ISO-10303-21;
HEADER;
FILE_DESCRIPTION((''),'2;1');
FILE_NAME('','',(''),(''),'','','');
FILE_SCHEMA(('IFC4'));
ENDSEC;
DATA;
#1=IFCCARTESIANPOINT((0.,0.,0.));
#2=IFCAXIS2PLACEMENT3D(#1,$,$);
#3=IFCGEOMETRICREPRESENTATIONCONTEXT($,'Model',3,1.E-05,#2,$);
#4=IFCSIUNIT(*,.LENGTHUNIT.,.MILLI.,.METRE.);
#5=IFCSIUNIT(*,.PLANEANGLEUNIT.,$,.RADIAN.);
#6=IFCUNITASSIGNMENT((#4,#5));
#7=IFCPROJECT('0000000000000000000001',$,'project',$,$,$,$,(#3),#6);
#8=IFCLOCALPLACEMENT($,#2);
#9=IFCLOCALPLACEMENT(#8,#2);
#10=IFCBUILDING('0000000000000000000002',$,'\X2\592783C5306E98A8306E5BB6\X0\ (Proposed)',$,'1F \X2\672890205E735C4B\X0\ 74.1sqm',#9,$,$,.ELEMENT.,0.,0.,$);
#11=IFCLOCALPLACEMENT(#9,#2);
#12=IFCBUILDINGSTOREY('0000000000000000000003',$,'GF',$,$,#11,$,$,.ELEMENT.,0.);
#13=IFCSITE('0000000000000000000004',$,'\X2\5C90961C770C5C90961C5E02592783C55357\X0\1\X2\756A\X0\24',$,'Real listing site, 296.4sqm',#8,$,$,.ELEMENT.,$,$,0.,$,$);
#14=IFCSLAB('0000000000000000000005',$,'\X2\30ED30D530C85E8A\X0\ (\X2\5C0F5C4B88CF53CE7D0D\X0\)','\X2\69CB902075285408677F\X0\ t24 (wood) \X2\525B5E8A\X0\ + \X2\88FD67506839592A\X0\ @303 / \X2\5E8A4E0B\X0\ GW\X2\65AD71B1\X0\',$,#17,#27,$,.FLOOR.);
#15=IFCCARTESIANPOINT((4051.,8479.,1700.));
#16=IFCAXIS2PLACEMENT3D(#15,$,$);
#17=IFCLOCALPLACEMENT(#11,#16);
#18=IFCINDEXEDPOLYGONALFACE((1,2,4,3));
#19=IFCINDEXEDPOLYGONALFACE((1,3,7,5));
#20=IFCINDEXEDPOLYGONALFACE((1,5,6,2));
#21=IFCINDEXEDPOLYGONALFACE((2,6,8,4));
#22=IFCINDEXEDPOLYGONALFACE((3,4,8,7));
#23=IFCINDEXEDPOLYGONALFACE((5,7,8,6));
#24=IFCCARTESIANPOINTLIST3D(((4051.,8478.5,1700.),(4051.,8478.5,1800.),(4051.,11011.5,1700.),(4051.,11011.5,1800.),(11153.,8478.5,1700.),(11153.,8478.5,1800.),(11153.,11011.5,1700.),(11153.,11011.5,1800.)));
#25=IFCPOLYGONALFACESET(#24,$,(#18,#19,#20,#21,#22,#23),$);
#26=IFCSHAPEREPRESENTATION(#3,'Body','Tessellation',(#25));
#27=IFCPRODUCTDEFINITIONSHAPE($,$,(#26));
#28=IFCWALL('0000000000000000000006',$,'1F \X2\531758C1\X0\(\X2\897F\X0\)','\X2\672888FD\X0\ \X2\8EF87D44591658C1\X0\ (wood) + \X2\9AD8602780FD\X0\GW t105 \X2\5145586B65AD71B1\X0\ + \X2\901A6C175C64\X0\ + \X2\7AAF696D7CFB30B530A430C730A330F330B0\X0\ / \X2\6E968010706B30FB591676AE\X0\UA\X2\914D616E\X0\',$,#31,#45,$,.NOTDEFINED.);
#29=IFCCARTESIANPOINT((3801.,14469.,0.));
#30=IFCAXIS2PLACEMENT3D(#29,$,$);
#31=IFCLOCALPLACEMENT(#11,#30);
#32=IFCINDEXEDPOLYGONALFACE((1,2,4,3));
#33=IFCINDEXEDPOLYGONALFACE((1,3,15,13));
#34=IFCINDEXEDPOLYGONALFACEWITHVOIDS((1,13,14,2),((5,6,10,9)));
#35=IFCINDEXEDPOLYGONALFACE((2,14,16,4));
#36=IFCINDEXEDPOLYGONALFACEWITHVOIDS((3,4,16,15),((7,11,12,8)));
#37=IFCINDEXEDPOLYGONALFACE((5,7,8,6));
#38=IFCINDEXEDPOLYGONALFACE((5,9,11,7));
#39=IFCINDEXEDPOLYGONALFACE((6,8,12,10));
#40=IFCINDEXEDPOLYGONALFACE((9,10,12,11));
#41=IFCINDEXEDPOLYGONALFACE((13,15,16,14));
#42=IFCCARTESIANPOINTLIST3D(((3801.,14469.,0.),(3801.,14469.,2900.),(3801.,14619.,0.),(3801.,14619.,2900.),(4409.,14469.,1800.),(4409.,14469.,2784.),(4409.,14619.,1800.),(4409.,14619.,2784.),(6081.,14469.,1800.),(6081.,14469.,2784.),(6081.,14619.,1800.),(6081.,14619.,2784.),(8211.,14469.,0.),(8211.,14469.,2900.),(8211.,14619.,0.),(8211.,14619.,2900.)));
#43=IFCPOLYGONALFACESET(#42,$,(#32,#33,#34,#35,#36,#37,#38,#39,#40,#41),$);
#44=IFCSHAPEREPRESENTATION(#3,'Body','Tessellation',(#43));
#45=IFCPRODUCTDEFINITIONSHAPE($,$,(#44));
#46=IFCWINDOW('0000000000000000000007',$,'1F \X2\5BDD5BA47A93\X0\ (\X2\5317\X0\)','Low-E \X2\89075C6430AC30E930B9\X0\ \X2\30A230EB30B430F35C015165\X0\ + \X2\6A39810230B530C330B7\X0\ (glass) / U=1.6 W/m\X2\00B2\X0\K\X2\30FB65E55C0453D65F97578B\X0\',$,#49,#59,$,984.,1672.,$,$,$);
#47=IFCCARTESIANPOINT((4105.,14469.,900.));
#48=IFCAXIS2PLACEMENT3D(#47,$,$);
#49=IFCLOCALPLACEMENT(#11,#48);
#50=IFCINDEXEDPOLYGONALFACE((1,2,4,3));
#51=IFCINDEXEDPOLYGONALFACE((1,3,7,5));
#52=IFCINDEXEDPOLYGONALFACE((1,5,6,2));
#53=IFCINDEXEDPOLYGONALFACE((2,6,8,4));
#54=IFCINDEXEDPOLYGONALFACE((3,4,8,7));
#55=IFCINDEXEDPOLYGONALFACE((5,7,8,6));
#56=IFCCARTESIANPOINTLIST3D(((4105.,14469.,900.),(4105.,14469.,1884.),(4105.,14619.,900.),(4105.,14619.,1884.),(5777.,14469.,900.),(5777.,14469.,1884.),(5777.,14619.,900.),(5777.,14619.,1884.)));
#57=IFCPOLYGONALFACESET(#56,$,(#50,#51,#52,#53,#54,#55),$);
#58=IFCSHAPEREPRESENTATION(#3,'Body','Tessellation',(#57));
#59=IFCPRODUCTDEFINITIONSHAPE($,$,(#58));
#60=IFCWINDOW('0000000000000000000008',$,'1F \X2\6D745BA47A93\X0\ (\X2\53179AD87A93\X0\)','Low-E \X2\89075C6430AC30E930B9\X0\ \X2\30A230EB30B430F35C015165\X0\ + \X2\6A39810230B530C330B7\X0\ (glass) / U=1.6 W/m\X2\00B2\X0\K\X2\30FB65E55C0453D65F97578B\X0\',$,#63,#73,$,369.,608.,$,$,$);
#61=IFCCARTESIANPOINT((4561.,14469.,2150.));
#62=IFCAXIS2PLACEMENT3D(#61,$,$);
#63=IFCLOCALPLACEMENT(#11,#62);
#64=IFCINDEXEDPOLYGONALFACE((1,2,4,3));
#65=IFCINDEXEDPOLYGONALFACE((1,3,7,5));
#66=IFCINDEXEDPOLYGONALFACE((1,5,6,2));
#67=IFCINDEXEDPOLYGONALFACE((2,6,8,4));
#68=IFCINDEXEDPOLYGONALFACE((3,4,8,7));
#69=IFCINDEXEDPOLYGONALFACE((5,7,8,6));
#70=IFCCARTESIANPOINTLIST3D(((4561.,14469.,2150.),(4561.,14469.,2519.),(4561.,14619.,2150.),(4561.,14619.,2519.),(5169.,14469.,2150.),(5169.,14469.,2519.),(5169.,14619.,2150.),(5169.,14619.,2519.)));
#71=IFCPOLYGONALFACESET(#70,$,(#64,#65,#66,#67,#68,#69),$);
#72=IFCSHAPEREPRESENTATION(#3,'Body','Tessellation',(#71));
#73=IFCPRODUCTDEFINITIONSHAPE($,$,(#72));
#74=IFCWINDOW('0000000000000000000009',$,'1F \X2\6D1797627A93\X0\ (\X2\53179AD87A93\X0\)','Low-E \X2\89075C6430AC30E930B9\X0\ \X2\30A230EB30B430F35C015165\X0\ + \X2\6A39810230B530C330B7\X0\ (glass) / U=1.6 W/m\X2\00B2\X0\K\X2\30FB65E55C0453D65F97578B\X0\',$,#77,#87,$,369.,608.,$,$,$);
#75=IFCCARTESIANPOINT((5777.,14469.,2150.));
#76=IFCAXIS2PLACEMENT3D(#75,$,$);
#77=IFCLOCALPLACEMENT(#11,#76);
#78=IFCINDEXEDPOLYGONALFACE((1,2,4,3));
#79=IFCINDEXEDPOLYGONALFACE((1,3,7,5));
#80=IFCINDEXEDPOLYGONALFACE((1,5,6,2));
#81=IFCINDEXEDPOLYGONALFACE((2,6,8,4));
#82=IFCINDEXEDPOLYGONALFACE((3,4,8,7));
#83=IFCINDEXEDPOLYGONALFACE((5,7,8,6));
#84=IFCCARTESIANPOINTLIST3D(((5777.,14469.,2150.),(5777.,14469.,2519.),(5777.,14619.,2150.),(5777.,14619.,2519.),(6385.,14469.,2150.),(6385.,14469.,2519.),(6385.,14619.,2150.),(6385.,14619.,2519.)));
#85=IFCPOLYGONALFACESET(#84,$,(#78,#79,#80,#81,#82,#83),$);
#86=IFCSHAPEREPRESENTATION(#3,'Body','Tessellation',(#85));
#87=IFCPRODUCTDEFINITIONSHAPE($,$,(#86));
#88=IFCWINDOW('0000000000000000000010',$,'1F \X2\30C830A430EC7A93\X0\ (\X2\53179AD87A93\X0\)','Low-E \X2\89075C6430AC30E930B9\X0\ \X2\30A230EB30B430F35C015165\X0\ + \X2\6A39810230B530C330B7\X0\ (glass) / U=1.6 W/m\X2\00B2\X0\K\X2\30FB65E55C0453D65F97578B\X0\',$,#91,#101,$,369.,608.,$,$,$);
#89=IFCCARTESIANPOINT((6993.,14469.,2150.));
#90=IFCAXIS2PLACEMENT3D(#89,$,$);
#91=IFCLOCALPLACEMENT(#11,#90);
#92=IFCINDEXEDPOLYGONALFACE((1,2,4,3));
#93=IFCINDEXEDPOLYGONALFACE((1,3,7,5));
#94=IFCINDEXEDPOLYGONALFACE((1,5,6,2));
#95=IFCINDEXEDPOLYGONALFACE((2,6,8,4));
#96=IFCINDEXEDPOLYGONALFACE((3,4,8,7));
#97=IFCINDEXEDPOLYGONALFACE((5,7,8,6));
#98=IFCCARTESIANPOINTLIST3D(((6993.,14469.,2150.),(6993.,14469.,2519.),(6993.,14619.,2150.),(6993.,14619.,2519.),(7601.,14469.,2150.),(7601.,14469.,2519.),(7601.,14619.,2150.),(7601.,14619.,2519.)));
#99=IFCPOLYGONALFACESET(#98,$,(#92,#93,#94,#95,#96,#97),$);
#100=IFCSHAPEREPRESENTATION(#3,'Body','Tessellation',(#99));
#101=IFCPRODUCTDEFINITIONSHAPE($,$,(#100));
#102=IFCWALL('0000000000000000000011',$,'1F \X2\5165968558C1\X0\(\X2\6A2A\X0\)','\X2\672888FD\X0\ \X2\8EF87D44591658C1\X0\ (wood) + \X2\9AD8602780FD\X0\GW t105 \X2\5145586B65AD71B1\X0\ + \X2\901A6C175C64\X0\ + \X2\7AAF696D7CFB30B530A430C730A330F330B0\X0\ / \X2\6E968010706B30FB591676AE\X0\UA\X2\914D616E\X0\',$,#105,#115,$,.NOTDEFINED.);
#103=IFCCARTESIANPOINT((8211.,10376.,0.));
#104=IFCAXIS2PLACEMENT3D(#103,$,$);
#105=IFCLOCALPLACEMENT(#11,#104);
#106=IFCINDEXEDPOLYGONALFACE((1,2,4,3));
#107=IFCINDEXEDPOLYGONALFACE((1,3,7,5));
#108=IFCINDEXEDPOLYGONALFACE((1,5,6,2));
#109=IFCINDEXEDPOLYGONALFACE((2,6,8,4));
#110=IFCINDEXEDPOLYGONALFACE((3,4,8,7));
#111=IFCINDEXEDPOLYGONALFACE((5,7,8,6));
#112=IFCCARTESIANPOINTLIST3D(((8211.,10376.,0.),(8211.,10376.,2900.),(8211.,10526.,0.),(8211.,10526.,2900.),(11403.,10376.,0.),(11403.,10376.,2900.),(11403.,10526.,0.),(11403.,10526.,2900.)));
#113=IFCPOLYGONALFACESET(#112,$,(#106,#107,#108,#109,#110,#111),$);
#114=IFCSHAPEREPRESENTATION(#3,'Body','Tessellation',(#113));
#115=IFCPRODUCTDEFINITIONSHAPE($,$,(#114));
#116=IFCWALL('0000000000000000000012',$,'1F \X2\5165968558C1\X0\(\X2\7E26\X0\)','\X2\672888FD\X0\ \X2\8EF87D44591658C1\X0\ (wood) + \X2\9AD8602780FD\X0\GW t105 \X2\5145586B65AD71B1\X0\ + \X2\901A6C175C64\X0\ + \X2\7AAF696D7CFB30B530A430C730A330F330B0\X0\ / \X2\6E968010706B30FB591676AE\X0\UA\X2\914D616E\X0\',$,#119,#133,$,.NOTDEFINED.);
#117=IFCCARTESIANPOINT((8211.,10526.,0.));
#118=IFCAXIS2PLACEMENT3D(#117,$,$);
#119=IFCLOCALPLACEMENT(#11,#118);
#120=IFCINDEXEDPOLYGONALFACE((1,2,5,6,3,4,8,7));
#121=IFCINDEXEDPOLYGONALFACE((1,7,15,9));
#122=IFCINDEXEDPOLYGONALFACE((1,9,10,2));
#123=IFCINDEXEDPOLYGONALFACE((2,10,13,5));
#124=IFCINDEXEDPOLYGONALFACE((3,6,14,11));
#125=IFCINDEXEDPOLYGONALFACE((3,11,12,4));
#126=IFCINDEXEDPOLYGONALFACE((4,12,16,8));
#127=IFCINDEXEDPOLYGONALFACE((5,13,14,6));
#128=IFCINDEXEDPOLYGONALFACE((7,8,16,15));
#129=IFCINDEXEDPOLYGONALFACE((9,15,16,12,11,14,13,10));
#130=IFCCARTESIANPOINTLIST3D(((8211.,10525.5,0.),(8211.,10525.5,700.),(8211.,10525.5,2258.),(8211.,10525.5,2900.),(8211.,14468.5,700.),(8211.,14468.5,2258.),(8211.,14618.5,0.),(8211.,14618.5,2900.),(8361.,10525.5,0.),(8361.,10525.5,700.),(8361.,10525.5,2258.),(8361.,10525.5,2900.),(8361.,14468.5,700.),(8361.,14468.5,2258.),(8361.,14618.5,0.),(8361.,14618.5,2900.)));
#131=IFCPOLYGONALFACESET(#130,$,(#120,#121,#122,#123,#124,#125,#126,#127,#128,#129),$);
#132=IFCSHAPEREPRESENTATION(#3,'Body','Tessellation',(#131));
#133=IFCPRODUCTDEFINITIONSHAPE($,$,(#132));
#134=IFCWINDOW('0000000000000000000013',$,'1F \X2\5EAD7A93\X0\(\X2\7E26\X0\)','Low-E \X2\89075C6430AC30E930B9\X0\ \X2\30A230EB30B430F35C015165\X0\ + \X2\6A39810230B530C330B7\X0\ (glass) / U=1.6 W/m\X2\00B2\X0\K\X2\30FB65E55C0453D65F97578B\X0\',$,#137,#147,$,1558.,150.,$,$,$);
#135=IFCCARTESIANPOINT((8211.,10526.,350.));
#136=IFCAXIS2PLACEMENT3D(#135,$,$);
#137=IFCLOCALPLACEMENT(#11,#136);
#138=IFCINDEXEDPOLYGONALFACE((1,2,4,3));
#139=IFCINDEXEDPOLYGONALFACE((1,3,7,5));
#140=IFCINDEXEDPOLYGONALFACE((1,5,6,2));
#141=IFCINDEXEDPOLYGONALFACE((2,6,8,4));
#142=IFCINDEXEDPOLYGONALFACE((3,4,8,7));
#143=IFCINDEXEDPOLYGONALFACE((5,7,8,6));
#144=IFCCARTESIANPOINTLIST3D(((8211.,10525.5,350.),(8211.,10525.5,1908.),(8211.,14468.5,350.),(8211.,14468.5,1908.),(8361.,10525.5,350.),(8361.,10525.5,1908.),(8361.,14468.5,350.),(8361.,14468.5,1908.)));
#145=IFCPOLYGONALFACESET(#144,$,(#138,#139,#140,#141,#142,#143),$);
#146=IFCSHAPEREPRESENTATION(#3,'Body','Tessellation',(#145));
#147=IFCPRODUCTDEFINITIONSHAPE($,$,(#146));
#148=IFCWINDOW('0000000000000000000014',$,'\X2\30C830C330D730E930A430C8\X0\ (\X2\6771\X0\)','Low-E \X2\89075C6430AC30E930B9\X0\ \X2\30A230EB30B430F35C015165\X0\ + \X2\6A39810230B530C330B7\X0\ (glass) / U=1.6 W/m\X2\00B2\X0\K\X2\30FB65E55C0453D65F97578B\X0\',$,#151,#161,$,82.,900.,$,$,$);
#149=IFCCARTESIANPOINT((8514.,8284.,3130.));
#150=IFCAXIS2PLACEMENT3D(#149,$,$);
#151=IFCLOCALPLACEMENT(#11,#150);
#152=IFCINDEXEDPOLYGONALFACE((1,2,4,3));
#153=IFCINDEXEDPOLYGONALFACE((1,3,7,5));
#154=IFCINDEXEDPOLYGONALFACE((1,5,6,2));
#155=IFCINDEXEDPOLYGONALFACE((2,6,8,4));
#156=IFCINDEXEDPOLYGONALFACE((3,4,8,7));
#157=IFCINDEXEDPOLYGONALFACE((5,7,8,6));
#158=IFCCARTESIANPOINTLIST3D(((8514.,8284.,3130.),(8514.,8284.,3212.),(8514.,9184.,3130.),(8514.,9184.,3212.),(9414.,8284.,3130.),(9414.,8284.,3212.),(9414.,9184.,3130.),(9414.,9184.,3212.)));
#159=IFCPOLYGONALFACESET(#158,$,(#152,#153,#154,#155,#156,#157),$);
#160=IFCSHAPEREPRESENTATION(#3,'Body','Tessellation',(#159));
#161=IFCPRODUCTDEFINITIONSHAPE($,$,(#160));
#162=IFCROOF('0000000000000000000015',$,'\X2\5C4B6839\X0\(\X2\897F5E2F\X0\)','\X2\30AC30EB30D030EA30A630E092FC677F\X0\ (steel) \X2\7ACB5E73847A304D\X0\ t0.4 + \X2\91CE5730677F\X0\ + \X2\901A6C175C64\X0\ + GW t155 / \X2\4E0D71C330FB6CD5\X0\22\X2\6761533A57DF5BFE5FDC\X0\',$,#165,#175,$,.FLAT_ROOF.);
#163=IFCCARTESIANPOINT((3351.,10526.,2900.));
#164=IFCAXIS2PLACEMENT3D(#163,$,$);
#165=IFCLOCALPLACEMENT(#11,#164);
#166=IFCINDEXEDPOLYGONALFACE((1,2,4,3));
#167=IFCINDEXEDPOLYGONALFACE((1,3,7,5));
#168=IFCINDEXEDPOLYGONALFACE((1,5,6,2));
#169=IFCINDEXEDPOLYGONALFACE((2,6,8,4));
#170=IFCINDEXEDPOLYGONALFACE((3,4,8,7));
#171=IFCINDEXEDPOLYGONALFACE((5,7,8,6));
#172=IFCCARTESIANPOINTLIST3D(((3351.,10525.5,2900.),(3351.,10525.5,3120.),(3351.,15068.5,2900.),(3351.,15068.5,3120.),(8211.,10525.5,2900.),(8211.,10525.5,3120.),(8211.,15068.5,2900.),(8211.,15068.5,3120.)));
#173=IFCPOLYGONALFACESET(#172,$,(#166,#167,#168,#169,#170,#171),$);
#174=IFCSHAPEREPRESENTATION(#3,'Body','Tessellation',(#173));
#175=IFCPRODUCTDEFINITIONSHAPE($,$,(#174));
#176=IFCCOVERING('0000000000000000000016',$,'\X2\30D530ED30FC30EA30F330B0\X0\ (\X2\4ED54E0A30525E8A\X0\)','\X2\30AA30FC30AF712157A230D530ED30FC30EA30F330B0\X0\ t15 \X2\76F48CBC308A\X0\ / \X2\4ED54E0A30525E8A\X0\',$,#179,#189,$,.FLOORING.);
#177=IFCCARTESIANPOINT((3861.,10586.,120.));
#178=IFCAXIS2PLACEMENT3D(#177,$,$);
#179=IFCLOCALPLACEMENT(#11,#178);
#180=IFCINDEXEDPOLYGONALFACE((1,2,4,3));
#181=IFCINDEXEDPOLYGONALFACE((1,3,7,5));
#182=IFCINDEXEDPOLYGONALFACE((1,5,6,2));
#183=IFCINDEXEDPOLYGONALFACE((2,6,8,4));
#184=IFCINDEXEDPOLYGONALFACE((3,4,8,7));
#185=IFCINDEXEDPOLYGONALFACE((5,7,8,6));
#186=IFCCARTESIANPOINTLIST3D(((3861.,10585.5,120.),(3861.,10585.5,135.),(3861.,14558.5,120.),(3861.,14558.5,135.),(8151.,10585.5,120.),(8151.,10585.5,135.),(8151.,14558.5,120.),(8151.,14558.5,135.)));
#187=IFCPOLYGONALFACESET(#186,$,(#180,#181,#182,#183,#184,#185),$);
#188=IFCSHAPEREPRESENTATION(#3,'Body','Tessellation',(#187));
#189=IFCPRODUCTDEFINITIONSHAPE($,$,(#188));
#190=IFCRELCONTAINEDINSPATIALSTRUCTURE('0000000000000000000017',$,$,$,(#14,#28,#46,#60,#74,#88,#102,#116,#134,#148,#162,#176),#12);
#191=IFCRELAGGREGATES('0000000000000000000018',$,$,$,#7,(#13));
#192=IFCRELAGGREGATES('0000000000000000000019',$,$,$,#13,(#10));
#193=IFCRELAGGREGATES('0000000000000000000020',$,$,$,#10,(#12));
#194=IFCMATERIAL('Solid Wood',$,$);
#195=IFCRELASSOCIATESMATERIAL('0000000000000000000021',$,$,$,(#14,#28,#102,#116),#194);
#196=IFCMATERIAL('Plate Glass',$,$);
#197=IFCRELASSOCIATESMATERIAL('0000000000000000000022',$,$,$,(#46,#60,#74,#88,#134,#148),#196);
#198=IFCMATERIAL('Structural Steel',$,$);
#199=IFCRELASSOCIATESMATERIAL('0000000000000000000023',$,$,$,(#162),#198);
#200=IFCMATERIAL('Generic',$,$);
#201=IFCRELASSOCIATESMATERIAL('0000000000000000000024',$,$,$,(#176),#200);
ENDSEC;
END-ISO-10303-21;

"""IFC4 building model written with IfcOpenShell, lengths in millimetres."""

from ifc_helpers import new_model, si_unit, frame, frame_2d, origin, place, context, project, spatial, rectangle, extrude, material, element, fill, save


model = new_model("IFC4")

# Units and contexts
model_context = context("Model", 3, precision=1e-05, world=origin())
ifc_project = project(units=[si_unit("LENGTHUNIT", "METRE", prefix="MILLI"), si_unit("PLANEANGLEUNIT", "RADIAN")], contexts=[model_context])

# Site, building, storey
site_placement = place(None, origin())
site = spatial("IfcSite", under=ifc_project, at=site_placement, Name="岐阜県岐阜市大菅南1番24", ObjectType="Real listing site, 296.4sqm", CompositionType="ELEMENT", RefElevation=0.0)
building_placement = place(site_placement, origin())
building = spatial("IfcBuilding", under=site, at=building_placement, Name="大菅の風の家 (Proposed)", ObjectType="1F 木造平屋 74.1sqm", CompositionType="ELEMENT", ElevationOfRefHeight=0.0, ElevationOfTerrain=0.0)
storey_placement = place(building_placement, origin())
storey = spatial("IfcBuildingStorey", under=building, at=storey_placement, Name="GF", CompositionType="ELEMENT", Elevation=0.0)

# Slab
ifc_material_1 = material(Name="Solid Wood")
slab_1_placement = place(storey_placement, frame((4051.0, 8479.0, 1700.0)))
element("IfcSlab", 1, at=slab_1_placement, inside=storey, material=ifc_material_1, Name="ロフト床 (小屋裏収納)", Description="構造用合板 t24 (wood) 剛床 + 製材根太 @303 / 床下 GW断熱", PredefinedType="FLOOR", context=model_context, shape_type="SweptSolid", body=[
    extrude(rectangle(XDim=7102.0, YDim=2533.0, at=frame_2d((3551.0, 1266.0))), frame((4051.0, 8479.0, 1700.0)), (0.0, 0.0, 1.0), 100.0),
])

# Wall, openings, windows
wall_1_placement = place(storey_placement, frame((3801.0, 14469.0, 0.0)))
wall_1 = element("IfcWall", 2, at=wall_1_placement, inside=storey, material=ifc_material_1, Name="1F 北壁(西)", Description="木製 軸組外壁 (wood) + 高性能GW t105 充填断熱 + 通気層 + 窯業系サイディング / 準耐火・外皮UA配慮", PredefinedType="NOTDEFINED", context=model_context, shape_type="SweptSolid", body=[
    extrude(rectangle(XDim=4410.0, YDim=150.0, at=frame_2d((2205.0, 75.0))), frame((3801.0, 14469.0, 0.0)), (0.0, 0.0, 1.0), 2900.0),
])
opening_1_placement = place(storey_placement, frame((4105.0, 14469.0, 900.0)))
opening_1 = element("IfcOpeningElement", 3, at=opening_1_placement, cuts=wall_1, PredefinedType="NOTDEFINED", context=model_context, shape_type="SweptSolid", body=[
    extrude(rectangle(XDim=1672.0, YDim=150.0, at=frame_2d((836.0, 75.0))), frame((4105.0, 14469.0, 900.0)), (0.0, 0.0, 1.0), 984.0),
])
opening_2_placement = place(storey_placement, frame((4561.0, 14469.0, 2150.0)))
opening_2 = element("IfcOpeningElement", 4, at=opening_2_placement, cuts=wall_1, PredefinedType="NOTDEFINED", context=model_context, shape_type="SweptSolid", body=[
    extrude(rectangle(XDim=608.0, YDim=150.0, at=frame_2d((304.0, 75.0))), frame((4561.0, 14469.0, 2150.0)), (0.0, 0.0, 1.0), 369.0),
])
opening_3_placement = place(storey_placement, frame((5777.0, 14469.0, 2150.0)))
opening_3 = element("IfcOpeningElement", 5, at=opening_3_placement, cuts=wall_1, PredefinedType="NOTDEFINED", context=model_context, shape_type="SweptSolid", body=[
    extrude(rectangle(XDim=608.0, YDim=150.0, at=frame_2d((304.0, 75.0))), frame((5777.0, 14469.0, 2150.0)), (0.0, 0.0, 1.0), 369.0),
])
opening_4_placement = place(storey_placement, frame((6993.0, 14469.0, 2150.0)))
opening_4 = element("IfcOpeningElement", 6, at=opening_4_placement, cuts=wall_1, PredefinedType="NOTDEFINED", context=model_context, shape_type="SweptSolid", body=[
    extrude(rectangle(XDim=608.0, YDim=150.0, at=frame_2d((304.0, 75.0))), frame((6993.0, 14469.0, 2150.0)), (0.0, 0.0, 1.0), 369.0),
])
ifc_material_2 = material(Name="Plate Glass")
window_1_placement = place(storey_placement, frame((4105.0, 14469.0, 900.0)))
window_1 = element("IfcWindow", 7, at=window_1_placement, inside=storey, material=ifc_material_2, Name="1F 寝室窓 (北)", Description="Low-E 複層ガラス アルゴン封入 + 樹脂サッシ (glass) / U=1.6 W/m²K・日射取得型", OverallHeight=984.0, OverallWidth=1672.0, context=model_context, shape_type="SweptSolid", body=[
    extrude(rectangle(XDim=1672.0, YDim=150.0, at=frame_2d((836.0, 75.0))), frame((4105.0, 14469.0, 900.0)), (0.0, 0.0, 1.0), 984.0),
])
fill(opening_1, window_1)
window_2_placement = place(storey_placement, frame((4561.0, 14469.0, 2150.0)))
window_2 = element("IfcWindow", 8, at=window_2_placement, inside=storey, material=ifc_material_2, Name="1F 浴室窓 (北高窓)", Description="Low-E 複層ガラス アルゴン封入 + 樹脂サッシ (glass) / U=1.6 W/m²K・日射取得型", OverallHeight=369.0, OverallWidth=608.0, context=model_context, shape_type="SweptSolid", body=[
    extrude(rectangle(XDim=608.0, YDim=150.0, at=frame_2d((304.0, 75.0))), frame((4561.0, 14469.0, 2150.0)), (0.0, 0.0, 1.0), 369.0),
])
fill(opening_2, window_2)
window_3_placement = place(storey_placement, frame((5777.0, 14469.0, 2150.0)))
window_3 = element("IfcWindow", 9, at=window_3_placement, inside=storey, material=ifc_material_2, Name="1F 洗面窓 (北高窓)", Description="Low-E 複層ガラス アルゴン封入 + 樹脂サッシ (glass) / U=1.6 W/m²K・日射取得型", OverallHeight=369.0, OverallWidth=608.0, context=model_context, shape_type="SweptSolid", body=[
    extrude(rectangle(XDim=608.0, YDim=150.0, at=frame_2d((304.0, 75.0))), frame((5777.0, 14469.0, 2150.0)), (0.0, 0.0, 1.0), 369.0),
])
fill(opening_3, window_3)
window_4_placement = place(storey_placement, frame((6993.0, 14469.0, 2150.0)))
window_4 = element("IfcWindow", 10, at=window_4_placement, inside=storey, material=ifc_material_2, Name="1F トイレ窓 (北高窓)", Description="Low-E 複層ガラス アルゴン封入 + 樹脂サッシ (glass) / U=1.6 W/m²K・日射取得型", OverallHeight=369.0, OverallWidth=608.0, context=model_context, shape_type="SweptSolid", body=[
    extrude(rectangle(XDim=608.0, YDim=150.0, at=frame_2d((304.0, 75.0))), frame((6993.0, 14469.0, 2150.0)), (0.0, 0.0, 1.0), 369.0),
])
fill(opening_4, window_4)

# Wall
wall_2_placement = place(storey_placement, frame((8211.0, 10376.0, 0.0)))
element("IfcWall", 11, at=wall_2_placement, inside=storey, material=ifc_material_1, Name="1F 入隅壁(横)", Description="木製 軸組外壁 (wood) + 高性能GW t105 充填断熱 + 通気層 + 窯業系サイディング / 準耐火・外皮UA配慮", PredefinedType="NOTDEFINED", context=model_context, shape_type="SweptSolid", body=[
    extrude(rectangle(XDim=3192.0, YDim=150.0, at=frame_2d((1596.0, 75.0))), frame((8211.0, 10376.0, 0.0)), (0.0, 0.0, 1.0), 2900.0),
])

# Wall, opening, window
wall_3_placement = place(storey_placement, frame((8211.0, 10526.0, 0.0)))
wall_3 = element("IfcWall", 12, at=wall_3_placement, inside=storey, material=ifc_material_1, Name="1F 入隅壁(縦)", Description="木製 軸組外壁 (wood) + 高性能GW t105 充填断熱 + 通気層 + 窯業系サイディング / 準耐火・外皮UA配慮", PredefinedType="NOTDEFINED", context=model_context, shape_type="SweptSolid", body=[
    extrude(rectangle(XDim=150.0, YDim=4093.0, at=frame_2d((75.0, 2046.0))), frame((8211.0, 10526.0, 0.0)), (0.0, 0.0, 1.0), 2900.0),
])
opening_5_placement = place(storey_placement, frame((8211.0, 10526.0, 350.0)))
opening_5 = element("IfcOpeningElement", 13, at=opening_5_placement, cuts=wall_3, PredefinedType="NOTDEFINED", context=model_context, shape_type="SweptSolid", body=[
    extrude(rectangle(XDim=150.0, YDim=3943.0, at=frame_2d((75.0, 1971.0))), frame((8211.0, 10526.0, 350.0)), (0.0, 0.0, 1.0), 1558.0),
])
window_5_placement = place(storey_placement, frame((8211.0, 10526.0, 350.0)))
window_5 = element("IfcWindow", 14, at=window_5_placement, inside=storey, material=ifc_material_2, Name="1F 庭窓(縦)", Description="Low-E 複層ガラス アルゴン封入 + 樹脂サッシ (glass) / U=1.6 W/m²K・日射取得型", OverallHeight=1558.0, OverallWidth=150.0, context=model_context, shape_type="SweptSolid", body=[
    extrude(rectangle(XDim=150.0, YDim=3943.0, at=frame_2d((75.0, 1971.0))), frame((8211.0, 10526.0, 350.0)), (0.0, 0.0, 1.0), 1558.0),
])
fill(opening_5, window_5)

# Window
window_6_placement = place(storey_placement, frame((8514.0, 8284.0, 3130.0)))
element("IfcWindow", 15, at=window_6_placement, inside=storey, material=ifc_material_2, Name="トップライト (東)", Description="Low-E 複層ガラス アルゴン封入 + 樹脂サッシ (glass) / U=1.6 W/m²K・日射取得型", OverallHeight=82.0, OverallWidth=900.0, context=model_context, shape_type="SweptSolid", body=[
    extrude(rectangle(XDim=900.0, YDim=900.0, at=frame_2d((450.0, 450.0))), frame((8514.0, 8284.0, 3130.0)), (0.0, 0.0, 1.0), 82.0),
])

# Roof
ifc_material_3 = material(Name="Structural Steel")
roof_placement = place(storey_placement, frame((3351.0, 10526.0, 2900.0)))
element("IfcRoof", 16, at=roof_placement, inside=storey, material=ifc_material_3, Name="屋根(西帯)", Description="ガルバリウム鋼板 (steel) 立平葺き t0.4 + 野地板 + 通気層 + GW t155 / 不燃・法22条区域対応", PredefinedType="FLAT_ROOF", context=model_context, shape_type="SweptSolid", body=[
    extrude(rectangle(XDim=4860.0, YDim=4543.0, at=frame_2d((2430.0, 2271.0))), frame((3351.0, 10526.0, 2900.0)), (0.0, 0.0, 1.0), 220.0),
])

# Covering
ifc_material_4 = material(Name="Generic")
covering_placement = place(storey_placement, frame((3861.0, 10586.0, 120.0)))
element("IfcCovering", 17, at=covering_placement, inside=storey, material=ifc_material_4, Name="フローリング (仕上げ床)", Description="オーク無垢フローリング t15 直貼り / 仕上げ床", PredefinedType="FLOORING", context=model_context, shape_type="SweptSolid", body=[
    extrude(rectangle(XDim=4290.0, YDim=3973.0, at=frame_2d((2145.0, 1986.0))), frame((3861.0, 10586.0, 120.0)), (0.0, 0.0, 1.0), 15.0),
])

save(model, "model.ifc")
